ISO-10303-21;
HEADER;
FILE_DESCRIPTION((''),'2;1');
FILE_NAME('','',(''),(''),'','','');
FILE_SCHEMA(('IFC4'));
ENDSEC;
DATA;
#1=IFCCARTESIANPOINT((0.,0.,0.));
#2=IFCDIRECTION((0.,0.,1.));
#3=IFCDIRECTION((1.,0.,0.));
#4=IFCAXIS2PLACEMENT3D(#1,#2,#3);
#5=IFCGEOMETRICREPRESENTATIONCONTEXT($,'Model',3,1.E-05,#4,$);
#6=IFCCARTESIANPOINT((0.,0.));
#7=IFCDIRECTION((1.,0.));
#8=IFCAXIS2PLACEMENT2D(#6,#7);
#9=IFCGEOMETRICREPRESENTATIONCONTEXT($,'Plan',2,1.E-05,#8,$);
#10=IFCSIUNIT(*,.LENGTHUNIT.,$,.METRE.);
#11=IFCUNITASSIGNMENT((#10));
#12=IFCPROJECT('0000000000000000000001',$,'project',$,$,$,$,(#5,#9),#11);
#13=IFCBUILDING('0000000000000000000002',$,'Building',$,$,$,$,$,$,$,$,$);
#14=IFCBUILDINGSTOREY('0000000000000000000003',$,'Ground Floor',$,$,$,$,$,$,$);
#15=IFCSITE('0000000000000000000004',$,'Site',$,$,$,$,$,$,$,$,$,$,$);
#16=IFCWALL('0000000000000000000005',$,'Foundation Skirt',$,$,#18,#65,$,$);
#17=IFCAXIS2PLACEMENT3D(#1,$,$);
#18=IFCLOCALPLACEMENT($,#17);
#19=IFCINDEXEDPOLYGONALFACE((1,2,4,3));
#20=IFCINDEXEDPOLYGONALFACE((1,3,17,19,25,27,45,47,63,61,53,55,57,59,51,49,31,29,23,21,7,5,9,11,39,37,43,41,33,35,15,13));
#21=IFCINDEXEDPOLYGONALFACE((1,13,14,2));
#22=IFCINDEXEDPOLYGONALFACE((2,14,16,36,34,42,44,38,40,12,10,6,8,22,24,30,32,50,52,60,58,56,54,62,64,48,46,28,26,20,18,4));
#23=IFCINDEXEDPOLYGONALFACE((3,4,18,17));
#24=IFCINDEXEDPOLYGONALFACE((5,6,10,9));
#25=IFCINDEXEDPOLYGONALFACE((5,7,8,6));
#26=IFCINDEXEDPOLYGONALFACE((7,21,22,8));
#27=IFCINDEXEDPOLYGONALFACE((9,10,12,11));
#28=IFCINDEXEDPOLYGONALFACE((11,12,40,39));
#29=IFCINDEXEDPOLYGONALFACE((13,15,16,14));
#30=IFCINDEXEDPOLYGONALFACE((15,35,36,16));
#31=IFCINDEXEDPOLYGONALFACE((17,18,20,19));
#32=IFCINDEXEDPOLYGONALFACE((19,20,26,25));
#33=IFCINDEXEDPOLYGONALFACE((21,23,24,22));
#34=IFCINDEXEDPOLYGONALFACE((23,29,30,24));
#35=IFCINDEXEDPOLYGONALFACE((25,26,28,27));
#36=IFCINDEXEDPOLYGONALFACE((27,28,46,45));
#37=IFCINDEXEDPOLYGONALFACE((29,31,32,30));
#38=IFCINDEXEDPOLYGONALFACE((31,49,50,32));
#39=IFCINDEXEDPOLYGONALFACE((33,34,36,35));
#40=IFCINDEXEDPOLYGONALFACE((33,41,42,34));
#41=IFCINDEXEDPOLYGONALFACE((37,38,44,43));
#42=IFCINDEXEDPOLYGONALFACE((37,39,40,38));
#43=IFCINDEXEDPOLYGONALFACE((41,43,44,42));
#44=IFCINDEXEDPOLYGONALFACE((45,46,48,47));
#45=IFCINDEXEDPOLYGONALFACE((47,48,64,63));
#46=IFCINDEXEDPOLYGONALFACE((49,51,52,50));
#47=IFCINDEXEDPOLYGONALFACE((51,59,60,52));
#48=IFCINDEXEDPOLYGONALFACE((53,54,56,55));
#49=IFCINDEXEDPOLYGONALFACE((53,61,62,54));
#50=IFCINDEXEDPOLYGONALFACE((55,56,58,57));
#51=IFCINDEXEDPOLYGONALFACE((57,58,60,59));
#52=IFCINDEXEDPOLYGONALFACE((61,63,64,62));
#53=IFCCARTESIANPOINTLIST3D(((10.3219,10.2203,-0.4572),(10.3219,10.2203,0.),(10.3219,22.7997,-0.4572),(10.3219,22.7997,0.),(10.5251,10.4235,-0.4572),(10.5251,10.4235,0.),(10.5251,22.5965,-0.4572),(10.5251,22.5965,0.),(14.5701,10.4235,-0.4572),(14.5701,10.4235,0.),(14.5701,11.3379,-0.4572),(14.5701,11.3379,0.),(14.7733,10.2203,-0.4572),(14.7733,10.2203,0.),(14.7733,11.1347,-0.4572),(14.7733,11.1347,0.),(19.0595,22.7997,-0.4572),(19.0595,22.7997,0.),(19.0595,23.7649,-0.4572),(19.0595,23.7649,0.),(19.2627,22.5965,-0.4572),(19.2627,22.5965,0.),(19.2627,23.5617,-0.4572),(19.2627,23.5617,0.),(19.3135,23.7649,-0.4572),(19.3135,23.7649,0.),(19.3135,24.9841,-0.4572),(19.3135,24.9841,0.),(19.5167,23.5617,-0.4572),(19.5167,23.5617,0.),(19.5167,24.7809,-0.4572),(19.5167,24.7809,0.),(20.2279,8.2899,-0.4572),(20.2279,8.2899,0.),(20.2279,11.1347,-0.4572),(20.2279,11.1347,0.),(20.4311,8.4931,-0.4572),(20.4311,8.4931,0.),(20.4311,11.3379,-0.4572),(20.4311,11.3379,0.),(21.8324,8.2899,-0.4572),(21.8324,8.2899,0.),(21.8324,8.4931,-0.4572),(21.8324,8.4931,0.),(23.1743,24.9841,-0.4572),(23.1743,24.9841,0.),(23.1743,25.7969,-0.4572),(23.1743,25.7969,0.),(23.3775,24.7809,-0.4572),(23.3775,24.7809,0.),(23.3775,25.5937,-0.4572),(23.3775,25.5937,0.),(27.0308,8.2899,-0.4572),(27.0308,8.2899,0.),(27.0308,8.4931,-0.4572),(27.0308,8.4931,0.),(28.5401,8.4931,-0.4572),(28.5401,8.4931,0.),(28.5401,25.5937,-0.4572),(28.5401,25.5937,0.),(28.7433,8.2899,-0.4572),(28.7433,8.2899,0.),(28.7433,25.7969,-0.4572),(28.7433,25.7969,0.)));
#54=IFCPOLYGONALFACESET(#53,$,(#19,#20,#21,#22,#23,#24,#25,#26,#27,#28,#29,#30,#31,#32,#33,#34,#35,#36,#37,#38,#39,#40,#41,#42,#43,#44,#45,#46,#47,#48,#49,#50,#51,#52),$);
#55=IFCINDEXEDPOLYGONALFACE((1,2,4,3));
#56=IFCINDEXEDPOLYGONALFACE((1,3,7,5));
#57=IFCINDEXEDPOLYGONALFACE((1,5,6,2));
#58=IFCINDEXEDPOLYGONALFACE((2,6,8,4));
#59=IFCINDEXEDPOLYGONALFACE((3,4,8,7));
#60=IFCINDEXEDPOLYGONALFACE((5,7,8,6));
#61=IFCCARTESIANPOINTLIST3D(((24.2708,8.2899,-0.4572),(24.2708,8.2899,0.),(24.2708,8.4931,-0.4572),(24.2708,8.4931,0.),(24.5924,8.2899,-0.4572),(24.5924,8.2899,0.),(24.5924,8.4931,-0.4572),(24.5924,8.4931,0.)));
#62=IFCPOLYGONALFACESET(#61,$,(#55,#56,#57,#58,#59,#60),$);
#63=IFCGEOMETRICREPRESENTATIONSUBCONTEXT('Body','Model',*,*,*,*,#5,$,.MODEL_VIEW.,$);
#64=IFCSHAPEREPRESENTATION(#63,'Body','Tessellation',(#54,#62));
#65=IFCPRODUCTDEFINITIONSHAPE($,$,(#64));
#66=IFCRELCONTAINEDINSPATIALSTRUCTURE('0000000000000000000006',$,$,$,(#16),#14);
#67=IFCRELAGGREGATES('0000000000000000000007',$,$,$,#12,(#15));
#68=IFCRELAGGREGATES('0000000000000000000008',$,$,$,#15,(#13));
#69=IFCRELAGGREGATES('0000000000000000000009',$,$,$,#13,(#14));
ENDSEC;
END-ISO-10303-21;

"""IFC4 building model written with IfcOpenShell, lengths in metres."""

from ifc_helpers import new_model, si_unit, frame, origin_with_axes, origin_2d_with_axis, place, context, subcontext, project, spatial, polyline, outline, extrude, element, save


model = new_model("IFC4")

# Units and contexts
model_context = context("Model", 3, precision=1e-05, world=origin_with_axes())
plan_context = context("Plan", 2, precision=1e-05, world=origin_2d_with_axis())
body_context = subcontext(model_context, "Body", "Model", "MODEL_VIEW")
ifc_project = project(units=[si_unit("LENGTHUNIT", "METRE")], contexts=[model_context, plan_context])

# Site, building, storey
site = spatial("IfcSite", under=ifc_project, Name="Site")
building = spatial("IfcBuilding", under=site, Name="Building")
storey = spatial("IfcBuildingStorey", under=building, Name="Ground Floor")

# Wall
wall_1_placement = place(None, frame((0.0, 0.0, -0.4572), z_axis=(0.0, 0.0, 1.0), x_axis=(1.0, 0.0, 0.0)))
element("IfcWall", 1, at=wall_1_placement, inside=storey, Name="Foundation Skirt", context=body_context, shape_type="SweptSolid", body=[
    extrude(outline(polyline([(14.7733, 11.1347), (20.2279, 11.1347), (20.2279, 8.2899), (21.8324, 8.2899), (21.8324, 8.4931), (20.4311, 8.4931), (20.4311, 11.3379), (14.5701, 11.3379), (14.5701, 10.4235), (10.5251, 10.4235), (10.5251, 22.5965), (19.2627, 22.5965), (19.2627, 23.5617), (19.5167, 23.5617), (19.5167, 24.7809), (23.3775, 24.7809), (23.3775, 25.5937), (28.5401, 25.5937), (28.5401, 8.4931), (27.0308, 8.4931), (27.0308, 8.2899), (28.7433, 8.2899), (28.7433, 25.7969), (23.1743, 25.7969), (23.1743, 24.9841), (19.3135, 24.9841), (19.3135, 23.7649), (19.0595, 23.7649), (19.0595, 22.7997), (10.3219, 22.7997), (10.3219, 10.2203), (14.7733, 10.2203), (14.7733, 11.1347)])), None, (0.0, 0.0, 1.0), 0.4572),
    extrude(outline(polyline([(24.5924, 8.2899), (24.5924, 8.4931), (24.2708, 8.4931), (24.2708, 8.2899), (24.5924, 8.2899)])), None, (0.0, 0.0, 1.0), 0.4572),
])

save(model, "model.ifc")
